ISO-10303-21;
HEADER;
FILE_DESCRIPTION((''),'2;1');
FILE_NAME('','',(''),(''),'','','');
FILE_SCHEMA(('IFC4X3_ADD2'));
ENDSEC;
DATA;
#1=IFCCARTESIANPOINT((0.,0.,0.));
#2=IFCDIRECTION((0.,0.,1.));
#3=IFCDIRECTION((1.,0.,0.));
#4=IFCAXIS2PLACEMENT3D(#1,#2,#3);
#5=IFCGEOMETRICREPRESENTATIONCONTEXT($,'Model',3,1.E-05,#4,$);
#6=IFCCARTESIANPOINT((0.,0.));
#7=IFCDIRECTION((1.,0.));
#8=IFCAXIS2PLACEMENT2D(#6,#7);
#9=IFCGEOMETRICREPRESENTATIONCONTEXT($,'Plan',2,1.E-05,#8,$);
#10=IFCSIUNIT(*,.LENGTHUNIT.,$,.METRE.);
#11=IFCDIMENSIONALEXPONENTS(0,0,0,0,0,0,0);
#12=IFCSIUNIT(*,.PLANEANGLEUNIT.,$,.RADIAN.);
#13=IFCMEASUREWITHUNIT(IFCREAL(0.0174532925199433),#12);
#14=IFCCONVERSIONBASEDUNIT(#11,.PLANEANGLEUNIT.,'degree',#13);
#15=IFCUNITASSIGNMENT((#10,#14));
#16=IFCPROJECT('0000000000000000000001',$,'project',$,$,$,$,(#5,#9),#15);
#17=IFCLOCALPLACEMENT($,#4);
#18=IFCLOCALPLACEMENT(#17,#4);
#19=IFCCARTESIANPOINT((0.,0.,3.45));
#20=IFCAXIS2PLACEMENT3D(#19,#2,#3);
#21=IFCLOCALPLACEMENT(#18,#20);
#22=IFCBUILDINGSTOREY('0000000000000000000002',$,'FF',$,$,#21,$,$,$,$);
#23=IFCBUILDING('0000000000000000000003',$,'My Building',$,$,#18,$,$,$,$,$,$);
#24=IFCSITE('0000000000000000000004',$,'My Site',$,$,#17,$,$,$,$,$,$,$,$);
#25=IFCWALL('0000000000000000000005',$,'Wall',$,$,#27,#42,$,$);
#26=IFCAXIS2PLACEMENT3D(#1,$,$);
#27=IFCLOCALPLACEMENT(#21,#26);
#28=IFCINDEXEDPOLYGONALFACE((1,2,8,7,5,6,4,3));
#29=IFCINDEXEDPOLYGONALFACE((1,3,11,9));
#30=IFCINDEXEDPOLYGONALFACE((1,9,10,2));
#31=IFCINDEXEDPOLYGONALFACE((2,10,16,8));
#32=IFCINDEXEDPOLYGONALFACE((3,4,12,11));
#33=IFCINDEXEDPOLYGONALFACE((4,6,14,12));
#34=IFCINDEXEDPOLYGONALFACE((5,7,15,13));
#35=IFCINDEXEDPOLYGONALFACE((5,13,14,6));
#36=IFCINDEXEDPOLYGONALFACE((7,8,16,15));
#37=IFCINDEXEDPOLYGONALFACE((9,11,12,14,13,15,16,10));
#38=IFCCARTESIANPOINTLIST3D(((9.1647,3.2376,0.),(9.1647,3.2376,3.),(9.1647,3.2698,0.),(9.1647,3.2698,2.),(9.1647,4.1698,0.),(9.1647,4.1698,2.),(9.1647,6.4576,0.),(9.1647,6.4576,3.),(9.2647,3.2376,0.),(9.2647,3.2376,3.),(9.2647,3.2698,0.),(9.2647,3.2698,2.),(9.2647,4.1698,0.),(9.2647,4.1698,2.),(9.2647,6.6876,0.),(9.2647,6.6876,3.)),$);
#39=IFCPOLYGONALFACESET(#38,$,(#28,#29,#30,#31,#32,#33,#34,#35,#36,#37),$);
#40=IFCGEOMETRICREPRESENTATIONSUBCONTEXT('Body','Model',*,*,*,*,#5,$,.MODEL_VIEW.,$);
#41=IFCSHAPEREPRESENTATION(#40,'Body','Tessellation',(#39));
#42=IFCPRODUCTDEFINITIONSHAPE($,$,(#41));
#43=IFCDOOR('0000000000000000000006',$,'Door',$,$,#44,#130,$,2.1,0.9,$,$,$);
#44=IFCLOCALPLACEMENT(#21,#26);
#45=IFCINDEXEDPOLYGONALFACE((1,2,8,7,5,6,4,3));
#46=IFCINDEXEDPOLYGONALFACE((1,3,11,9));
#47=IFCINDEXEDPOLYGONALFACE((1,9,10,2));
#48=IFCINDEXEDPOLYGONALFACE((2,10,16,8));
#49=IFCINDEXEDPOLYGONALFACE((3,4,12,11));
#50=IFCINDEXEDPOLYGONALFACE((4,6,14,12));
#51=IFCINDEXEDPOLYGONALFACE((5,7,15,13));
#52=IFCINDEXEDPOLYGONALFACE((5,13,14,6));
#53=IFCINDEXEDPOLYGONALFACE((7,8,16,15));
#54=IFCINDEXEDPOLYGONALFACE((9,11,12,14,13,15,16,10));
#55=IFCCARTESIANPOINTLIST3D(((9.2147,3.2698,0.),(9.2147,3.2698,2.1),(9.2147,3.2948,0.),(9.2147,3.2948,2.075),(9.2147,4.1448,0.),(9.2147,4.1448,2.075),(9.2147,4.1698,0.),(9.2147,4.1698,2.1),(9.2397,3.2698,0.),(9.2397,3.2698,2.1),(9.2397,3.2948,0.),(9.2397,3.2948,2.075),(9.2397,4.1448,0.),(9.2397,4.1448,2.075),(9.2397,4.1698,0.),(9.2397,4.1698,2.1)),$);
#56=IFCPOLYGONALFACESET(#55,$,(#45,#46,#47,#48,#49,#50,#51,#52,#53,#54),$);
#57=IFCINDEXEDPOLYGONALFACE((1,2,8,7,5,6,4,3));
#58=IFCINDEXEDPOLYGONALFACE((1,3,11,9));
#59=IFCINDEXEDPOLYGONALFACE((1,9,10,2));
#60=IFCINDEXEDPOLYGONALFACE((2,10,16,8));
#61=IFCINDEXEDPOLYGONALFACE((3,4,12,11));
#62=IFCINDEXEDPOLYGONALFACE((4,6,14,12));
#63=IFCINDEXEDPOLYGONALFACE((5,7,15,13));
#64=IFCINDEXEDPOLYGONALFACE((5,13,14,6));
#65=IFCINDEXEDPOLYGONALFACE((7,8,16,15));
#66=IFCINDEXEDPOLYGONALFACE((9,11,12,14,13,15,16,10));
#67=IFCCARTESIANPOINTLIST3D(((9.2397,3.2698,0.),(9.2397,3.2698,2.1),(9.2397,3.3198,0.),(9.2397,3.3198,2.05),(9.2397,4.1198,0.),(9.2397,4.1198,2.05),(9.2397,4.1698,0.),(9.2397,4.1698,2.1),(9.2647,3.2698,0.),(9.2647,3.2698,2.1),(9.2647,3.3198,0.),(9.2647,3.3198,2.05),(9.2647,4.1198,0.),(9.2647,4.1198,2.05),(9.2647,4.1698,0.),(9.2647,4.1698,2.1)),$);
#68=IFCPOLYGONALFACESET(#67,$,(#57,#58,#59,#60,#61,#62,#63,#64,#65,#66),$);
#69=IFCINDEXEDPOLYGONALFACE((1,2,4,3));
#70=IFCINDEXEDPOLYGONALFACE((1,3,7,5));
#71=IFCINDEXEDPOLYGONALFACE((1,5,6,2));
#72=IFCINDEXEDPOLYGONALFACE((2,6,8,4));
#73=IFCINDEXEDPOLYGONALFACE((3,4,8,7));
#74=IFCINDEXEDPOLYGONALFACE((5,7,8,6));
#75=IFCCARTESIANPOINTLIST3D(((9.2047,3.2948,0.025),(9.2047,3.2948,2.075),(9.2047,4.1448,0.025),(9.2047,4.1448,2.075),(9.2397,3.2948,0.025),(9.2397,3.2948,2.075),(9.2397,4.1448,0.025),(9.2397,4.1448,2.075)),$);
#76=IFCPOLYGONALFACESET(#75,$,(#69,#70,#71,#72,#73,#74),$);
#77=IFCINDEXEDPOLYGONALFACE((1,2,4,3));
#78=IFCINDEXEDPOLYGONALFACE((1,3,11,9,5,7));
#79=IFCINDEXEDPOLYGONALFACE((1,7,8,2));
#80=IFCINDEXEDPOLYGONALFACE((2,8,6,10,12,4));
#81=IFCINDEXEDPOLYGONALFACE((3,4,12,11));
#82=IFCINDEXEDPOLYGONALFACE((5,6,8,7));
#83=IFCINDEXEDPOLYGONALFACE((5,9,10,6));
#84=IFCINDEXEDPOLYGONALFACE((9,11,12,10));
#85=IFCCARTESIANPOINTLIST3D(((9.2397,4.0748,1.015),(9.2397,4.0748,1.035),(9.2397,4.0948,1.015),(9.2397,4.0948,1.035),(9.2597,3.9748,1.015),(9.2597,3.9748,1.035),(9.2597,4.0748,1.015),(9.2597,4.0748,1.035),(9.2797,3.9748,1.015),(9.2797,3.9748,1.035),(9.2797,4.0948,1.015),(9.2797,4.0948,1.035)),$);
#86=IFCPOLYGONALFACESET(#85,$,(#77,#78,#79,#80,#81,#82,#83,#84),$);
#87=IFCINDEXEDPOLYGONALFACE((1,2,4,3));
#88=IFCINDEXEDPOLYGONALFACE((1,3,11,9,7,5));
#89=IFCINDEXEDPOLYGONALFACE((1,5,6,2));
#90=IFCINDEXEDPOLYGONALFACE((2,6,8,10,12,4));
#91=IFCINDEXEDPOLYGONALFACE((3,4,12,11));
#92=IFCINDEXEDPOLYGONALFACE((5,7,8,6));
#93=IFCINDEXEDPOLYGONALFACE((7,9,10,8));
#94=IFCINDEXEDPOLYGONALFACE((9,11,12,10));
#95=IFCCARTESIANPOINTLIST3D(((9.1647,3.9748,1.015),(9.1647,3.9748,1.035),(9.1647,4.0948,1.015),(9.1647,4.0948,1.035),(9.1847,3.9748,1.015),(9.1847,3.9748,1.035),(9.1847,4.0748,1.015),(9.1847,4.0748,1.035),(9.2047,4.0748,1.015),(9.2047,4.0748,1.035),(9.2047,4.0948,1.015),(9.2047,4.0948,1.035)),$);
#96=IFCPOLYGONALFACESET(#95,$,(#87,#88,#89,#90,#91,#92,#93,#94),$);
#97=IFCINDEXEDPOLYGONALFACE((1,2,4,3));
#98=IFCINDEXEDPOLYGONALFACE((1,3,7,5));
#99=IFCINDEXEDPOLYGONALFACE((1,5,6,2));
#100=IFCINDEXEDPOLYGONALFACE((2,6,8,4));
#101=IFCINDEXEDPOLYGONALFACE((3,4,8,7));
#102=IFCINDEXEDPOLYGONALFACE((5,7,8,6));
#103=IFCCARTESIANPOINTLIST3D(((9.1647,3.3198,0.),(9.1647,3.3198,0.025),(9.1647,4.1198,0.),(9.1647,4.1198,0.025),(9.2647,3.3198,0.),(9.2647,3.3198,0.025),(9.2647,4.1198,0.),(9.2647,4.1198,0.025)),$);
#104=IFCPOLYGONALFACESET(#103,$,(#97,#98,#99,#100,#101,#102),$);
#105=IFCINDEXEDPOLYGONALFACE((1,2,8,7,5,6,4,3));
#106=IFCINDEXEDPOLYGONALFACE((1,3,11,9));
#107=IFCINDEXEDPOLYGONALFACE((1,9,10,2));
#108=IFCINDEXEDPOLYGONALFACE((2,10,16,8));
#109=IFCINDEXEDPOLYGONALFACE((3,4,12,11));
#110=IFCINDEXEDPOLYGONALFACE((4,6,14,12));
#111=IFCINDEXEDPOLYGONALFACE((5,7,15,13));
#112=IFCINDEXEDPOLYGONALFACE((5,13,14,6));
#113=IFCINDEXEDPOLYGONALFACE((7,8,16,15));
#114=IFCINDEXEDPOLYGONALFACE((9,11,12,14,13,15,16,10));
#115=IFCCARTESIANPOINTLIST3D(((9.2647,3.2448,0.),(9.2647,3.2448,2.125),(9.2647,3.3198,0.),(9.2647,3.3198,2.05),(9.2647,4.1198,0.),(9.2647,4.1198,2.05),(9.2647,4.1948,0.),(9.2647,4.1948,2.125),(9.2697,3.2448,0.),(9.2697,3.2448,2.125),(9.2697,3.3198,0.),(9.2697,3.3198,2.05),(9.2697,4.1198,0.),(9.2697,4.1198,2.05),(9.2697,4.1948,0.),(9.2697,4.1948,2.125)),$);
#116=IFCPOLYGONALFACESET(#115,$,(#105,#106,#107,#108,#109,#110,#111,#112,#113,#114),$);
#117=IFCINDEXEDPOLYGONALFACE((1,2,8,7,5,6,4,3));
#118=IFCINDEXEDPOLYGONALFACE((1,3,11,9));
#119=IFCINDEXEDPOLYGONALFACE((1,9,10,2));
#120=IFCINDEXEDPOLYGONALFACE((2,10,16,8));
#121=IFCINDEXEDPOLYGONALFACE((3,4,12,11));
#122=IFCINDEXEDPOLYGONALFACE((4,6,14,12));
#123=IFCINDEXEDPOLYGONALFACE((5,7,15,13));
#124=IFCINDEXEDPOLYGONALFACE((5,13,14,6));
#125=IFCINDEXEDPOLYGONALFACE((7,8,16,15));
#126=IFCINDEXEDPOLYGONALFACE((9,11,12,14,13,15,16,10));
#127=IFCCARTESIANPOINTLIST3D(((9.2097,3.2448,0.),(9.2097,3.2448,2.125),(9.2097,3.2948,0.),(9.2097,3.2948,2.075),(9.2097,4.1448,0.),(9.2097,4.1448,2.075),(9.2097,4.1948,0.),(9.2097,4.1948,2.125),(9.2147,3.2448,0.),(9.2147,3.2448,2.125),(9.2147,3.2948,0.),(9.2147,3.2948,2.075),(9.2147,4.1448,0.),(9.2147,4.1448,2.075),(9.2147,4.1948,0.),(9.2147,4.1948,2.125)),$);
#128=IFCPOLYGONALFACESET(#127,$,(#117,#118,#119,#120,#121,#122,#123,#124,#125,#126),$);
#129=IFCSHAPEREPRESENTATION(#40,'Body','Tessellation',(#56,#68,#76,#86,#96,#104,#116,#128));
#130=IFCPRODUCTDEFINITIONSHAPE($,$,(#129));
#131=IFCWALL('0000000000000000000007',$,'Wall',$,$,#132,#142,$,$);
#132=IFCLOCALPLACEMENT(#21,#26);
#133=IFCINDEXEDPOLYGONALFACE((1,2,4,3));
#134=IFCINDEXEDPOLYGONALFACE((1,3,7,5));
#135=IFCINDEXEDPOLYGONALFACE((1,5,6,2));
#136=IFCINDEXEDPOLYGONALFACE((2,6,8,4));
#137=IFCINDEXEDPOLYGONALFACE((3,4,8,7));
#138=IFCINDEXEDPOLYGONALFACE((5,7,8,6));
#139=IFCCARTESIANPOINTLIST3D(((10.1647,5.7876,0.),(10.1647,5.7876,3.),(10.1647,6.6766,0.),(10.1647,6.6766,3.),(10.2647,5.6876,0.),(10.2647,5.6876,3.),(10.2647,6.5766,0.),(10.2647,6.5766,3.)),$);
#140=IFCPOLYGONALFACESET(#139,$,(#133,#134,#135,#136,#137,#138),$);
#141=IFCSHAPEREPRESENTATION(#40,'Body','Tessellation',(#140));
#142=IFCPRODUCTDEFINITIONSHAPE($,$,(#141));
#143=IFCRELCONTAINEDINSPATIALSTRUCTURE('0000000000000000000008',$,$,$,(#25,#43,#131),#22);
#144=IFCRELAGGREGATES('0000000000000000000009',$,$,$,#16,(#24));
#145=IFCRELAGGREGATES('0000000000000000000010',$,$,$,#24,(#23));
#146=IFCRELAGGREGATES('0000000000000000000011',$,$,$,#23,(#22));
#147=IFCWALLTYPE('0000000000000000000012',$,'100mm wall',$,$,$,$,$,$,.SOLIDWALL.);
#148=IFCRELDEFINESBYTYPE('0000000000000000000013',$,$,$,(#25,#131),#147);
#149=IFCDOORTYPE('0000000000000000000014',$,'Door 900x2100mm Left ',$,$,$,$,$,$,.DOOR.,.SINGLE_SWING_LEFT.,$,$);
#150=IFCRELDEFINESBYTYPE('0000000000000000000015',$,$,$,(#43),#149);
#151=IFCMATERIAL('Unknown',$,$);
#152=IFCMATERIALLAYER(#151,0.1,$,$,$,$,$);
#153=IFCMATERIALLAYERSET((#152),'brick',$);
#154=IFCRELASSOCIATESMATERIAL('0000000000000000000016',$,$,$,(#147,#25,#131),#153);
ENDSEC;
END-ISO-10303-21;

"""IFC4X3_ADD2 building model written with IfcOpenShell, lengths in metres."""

from ifc_helpers import new_model, entity, si_unit, converted_unit, frame, origin_with_axes, origin_2d_with_axis, place, context, subcontext, project, spatial, line, indexed_curve, outline, extrude, shape, source, transform, mapped, material, layer, layer_set, layer_usage, type_object, type_shapes, element, fill, save


model = new_model("IFC4X3_ADD2")

# Units and contexts
model_context = context("Model", 3, precision=1e-05, world=origin_with_axes())
plan_context = context("Plan", 2, precision=1e-05, world=origin_2d_with_axis())
body_context_1 = subcontext(model_context, "Body", "Model", "MODEL_VIEW")
body_context_2 = subcontext(plan_context, "Body", "Plan", "PLAN_VIEW")
ifc_project = project(units=[si_unit("LENGTHUNIT", "METRE"), converted_unit("PLANEANGLEUNIT", "degree", entity("IfcReal", 0.0174532925199433), si_unit("PLANEANGLEUNIT", "RADIAN"), dimensions=[0, 0, 0, 0, 0, 0, 0])], contexts=[model_context, plan_context])

# Site, building, storey
site_placement = place(None, origin_with_axes())
site = spatial("IfcSite", under=ifc_project, at=site_placement, Name="My Site")
building_placement = place(site_placement, origin_with_axes())
building = spatial("IfcBuilding", under=site, at=building_placement, Name="My Building")
storey_placement = place(building_placement, frame((0.0, 0.0, 3.45), z_axis=(0.0, 0.0, 1.0), x_axis=(1.0, 0.0, 0.0)))
storey = spatial("IfcBuildingStorey", under=building, at=storey_placement, Name="FF")

# Shared definitions
ifc_material = material(Name="Unknown")

# Shared definitions
shared_shape_1 = source(origin_with_axes(), body_context_1, "Body", "SweptSolid", [
    extrude(outline(indexed_curve([(0.0, 0.0), (0.9, 0.0), (0.9, 2.1), (0.0, 2.1)], segments=[line(1, 2, 3, 4, 1)])), frame((0.0, -0.6, 0.0), z_axis=(0.0, -1.0, 0.0), x_axis=(1.0, 0.0, 0.0)), (0.0, 0.0, -1.0), 1.2),
])
door_type_1 = type_object("IfcDoorType", Name="Door 900x2100mm Left ", OperationType="SINGLE_SWING_LEFT", PredefinedType="DOOR")
shared_shape_2 = source(origin_with_axes(), body_context_1, "Body", "SweptSolid", [
    extrude(outline(indexed_curve([(0.0, 0.0), (0.0, 2.1), (0.9, 2.1), (0.9, 0.0), (0.875, 0.0), (0.875, 2.075), (0.025, 2.075), (0.025, 0.0)], segments=[line(1, 2, 3, 4, 5, 6, 7, 8, 1)])), frame((0.0, 0.025, 0.0), z_axis=(0.0, -1.0, 0.0), x_axis=(1.0, 0.0, 0.0)), (0.0, 0.0, -1.0), 0.025),
    extrude(outline(indexed_curve([(0.0, 0.0), (0.0, 2.1), (0.9, 2.1), (0.9, 0.0), (0.85, 0.0), (0.85, 2.05), (0.05, 2.05), (0.05, 0.0)], segments=[line(1, 2, 3, 4, 5, 6, 7, 8, 1)])), frame((0.0, 0.0, 0.0), z_axis=(0.0, -1.0, 0.0), x_axis=(1.0, 0.0, 0.0)), (0.0, 0.0, -1.0), 0.025),
    extrude(outline(indexed_curve([(0.0, 0.0), (0.85, 0.0), (0.85, 0.035), (0.0, 0.035)], segments=[line(1, 2, 3, 4, 1)])), frame((0.025, 0.025, 0.025), z_axis=(0.0, 0.0, 1.0), x_axis=(1.0, 0.0, 0.0)), (0.0, 0.0, 1.0), 2.05),
    extrude(outline(indexed_curve([(0.0, 0.0), (0.0, -0.04), (-0.12, -0.04), (-0.12, -0.02), (-0.02, -0.02), (-0.02, 0.0)], segments=[line(1, 2, 3, 4, 5, 6, 1)])), frame((0.825, 0.025, 1.015), z_axis=(0.0, 0.0, 1.0), x_axis=(1.0, 0.0, 0.0)), (0.0, 0.0, 1.0), 0.02),
    extrude(outline(indexed_curve([(0.0, 0.0), (0.0, 0.04), (-0.12, 0.04), (-0.12, 0.02), (-0.02, 0.02), (-0.02, 0.0)], segments=[line(1, 2, 3, 4, 5, 6, 1)])), frame((0.825, 0.06, 1.015), z_axis=(0.0, 0.0, 1.0), x_axis=(1.0, 0.0, 0.0)), (0.0, 0.0, 1.0), 0.02),
    extrude(outline(indexed_curve([(0.0, 0.0), (0.8, 0.0), (0.8, 0.1), (0.0, 0.1)], segments=[line(1, 2, 3, 4, 1)])), frame((0.05, 0.0, 0.0), z_axis=(0.0, 0.0, 1.0), x_axis=(1.0, 0.0, 0.0)), (0.0, 0.0, 1.0), 0.025),
    extrude(outline(indexed_curve([(0.0, 0.0), (0.0, 2.125), (0.95, 2.125), (0.95, 0.0), (0.875, 0.0), (0.875, 2.05), (0.075, 2.05), (0.075, 0.0)], segments=[line(1, 2, 3, 4, 5, 6, 7, 8, 1)])), frame((-0.025, -0.005, 0.0), z_axis=(0.0, -1.0, 0.0), x_axis=(1.0, 0.0, 0.0)), (0.0, 0.0, -1.0), 0.005),
    extrude(outline(indexed_curve([(0.0, 0.0), (0.0, 2.125), (0.95, 2.125), (0.95, 0.0), (0.9, 0.0), (0.9, 2.075), (0.05, 2.075), (0.05, 0.0)], segments=[line(1, 2, 3, 4, 5, 6, 7, 8, 1)])), frame((-0.025, 0.05, 0.0), z_axis=(0.0, -1.0, 0.0), x_axis=(1.0, 0.0, 0.0)), (0.0, 0.0, -1.0), 0.005),
])
shared_shape_3 = source(origin_with_axes(), body_context_2, "Body", "Curve2D", [
    entity("IfcIndexedPolyCurve", entity("IfcCartesianPointList2D", [[0.0, 0.0], [0.0, 0.05], [0.025, 0.05], [0.025, 0.025], [0.05, 0.025], [0.05, 0.0]]), [entity("IfcLineIndex", [1, 2, 3, 4, 5, 6, 1])]),
    entity("IfcIndexedPolyCurve", entity("IfcCartesianPointList2D", [[0.9, 0.0], [0.9, 0.05], [0.875, 0.05], [0.875, 0.025], [0.85, 0.025], [0.85, 0.0]]), [entity("IfcLineIndex", [1, 2, 3, 4, 5, 6, 1])]),
    entity("IfcTrimmedCurve", entity("IfcEllipse", entity("IfcAxis2Placement2D", entity("IfcCartesianPoint", [0.06, 0.05]), entity("IfcDirection", [1.0, 0.0])), 0.815, 0.85), [entity("IfcCartesianPoint", [0.875, 0.05])], [entity("IfcCartesianPoint", [0.06, 0.9])], True, "CARTESIAN"),
    entity("IfcIndexedPolyCurve", entity("IfcCartesianPointList2D", [[0.025, 0.05], [0.06, 0.05], [0.06, 0.9], [0.025, 0.9]]), [entity("IfcLineIndex", [1, 2, 3, 4, 1])]),
])
type_shapes(door_type_1, [shared_shape_2, shared_shape_3])
ifc_layer_1 = layer(ifc_material, 0.1)
ifc_layer_set_1 = layer_set([ifc_layer_1], Name="brick")
wall_type_1 = type_object("IfcWallType", Name="100mm wall", PredefinedType="SOLIDWALL", material=ifc_layer_set_1)

# Wall, opening, door
ifc_layer_usage_1 = layer_usage(ifc_layer_set_1, "AXIS2", "POSITIVE", 0.0)
wall_1_placement = place(storey_placement, frame((9.2647, 3.2376, 0.0), z_axis=(0.0, 0.0, 1.0), x_axis=(0.0, 1.0, 0.0)))
wall_1 = element("IfcWall", 1, at=wall_1_placement, inside=storey, type_object=wall_type_1, material=ifc_layer_usage_1, Name="Wall", context=body_context_1, shape_type="SweptSolid", body=[
    extrude(outline(indexed_curve([(0.0, 0.0), (0.0, 0.1), (3.22, 0.1), (3.45, 0.0)], segments=[line(1, 2, 3, 4, 1)])), origin_with_axes(), (0.0, 0.0, 1.0), 3.0),
])
opening_1_placement = place(wall_1_placement, frame((0.0322, 0.0, -0.1), z_axis=(0.0, 0.0, 1.0), x_axis=(1.0, 0.0, 0.0)))
opening_1 = element("IfcOpeningElement", 2, at=opening_1_placement, cuts=wall_1, PredefinedType="OPENING", context=body_context_1, shape_type="MappedRepresentation", body=[
    mapped(shared_shape_1, transform((0.0, 0.0, 0.0), x_axis=(1.0, 0.0, 0.0), y_axis=(0.0, 1.0, 0.0), z_axis=(0.0, 0.0, 1.0), scale=1.0)),
])
door_1_placement = place(opening_1_placement, frame((0.0, 0.0, 0.1), z_axis=(0.0, 0.0, 1.0), x_axis=(1.0, 0.0, 0.0)))
door_1 = element("IfcDoor", 3, at=door_1_placement, inside=storey, type_object=door_type_1, Name="Door", OverallHeight=2.1, OverallWidth=0.9, shapes=[
    shape(body_context_1, "Body", "MappedRepresentation", [mapped(shared_shape_2, transform((0.0, 0.0, 0.0), x_axis=(1.0, 0.0, 0.0), y_axis=(0.0, 1.0, 0.0), z_axis=(0.0, 0.0, 1.0), scale=1.0))]),
    shape(body_context_2, "Body", "MappedRepresentation", [mapped(shared_shape_3, transform((0.0, 0.0, 0.0), x_axis=(1.0, 0.0, 0.0), y_axis=(0.0, 1.0, 0.0), z_axis=(0.0, 0.0, 1.0), scale=1.0))]),
])
fill(opening_1, door_1)

# Wall
ifc_layer_usage_2 = layer_usage(ifc_layer_set_1, "AXIS2", "POSITIVE", 0.0)
wall_2_placement = place(storey_placement, frame((10.2647, 5.7876, 0.0), z_axis=(0.0, 0.0, 1.0), x_axis=(0.0, 1.0, 0.0)))
element("IfcWall", 4, at=wall_2_placement, inside=storey, type_object=wall_type_1, material=ifc_layer_usage_2, Name="Wall", context=body_context_1, shape_type="SweptSolid", body=[
    extrude(outline(indexed_curve([(-0.1, 0.0), (0.0, 0.1), (0.889, 0.1), (0.789, 0.0)], segments=[line(1, 2, 3, 4, 1)])), origin_with_axes(), (0.0, 0.0, 1.0), 3.0),
])

save(model, "model.ifc")
